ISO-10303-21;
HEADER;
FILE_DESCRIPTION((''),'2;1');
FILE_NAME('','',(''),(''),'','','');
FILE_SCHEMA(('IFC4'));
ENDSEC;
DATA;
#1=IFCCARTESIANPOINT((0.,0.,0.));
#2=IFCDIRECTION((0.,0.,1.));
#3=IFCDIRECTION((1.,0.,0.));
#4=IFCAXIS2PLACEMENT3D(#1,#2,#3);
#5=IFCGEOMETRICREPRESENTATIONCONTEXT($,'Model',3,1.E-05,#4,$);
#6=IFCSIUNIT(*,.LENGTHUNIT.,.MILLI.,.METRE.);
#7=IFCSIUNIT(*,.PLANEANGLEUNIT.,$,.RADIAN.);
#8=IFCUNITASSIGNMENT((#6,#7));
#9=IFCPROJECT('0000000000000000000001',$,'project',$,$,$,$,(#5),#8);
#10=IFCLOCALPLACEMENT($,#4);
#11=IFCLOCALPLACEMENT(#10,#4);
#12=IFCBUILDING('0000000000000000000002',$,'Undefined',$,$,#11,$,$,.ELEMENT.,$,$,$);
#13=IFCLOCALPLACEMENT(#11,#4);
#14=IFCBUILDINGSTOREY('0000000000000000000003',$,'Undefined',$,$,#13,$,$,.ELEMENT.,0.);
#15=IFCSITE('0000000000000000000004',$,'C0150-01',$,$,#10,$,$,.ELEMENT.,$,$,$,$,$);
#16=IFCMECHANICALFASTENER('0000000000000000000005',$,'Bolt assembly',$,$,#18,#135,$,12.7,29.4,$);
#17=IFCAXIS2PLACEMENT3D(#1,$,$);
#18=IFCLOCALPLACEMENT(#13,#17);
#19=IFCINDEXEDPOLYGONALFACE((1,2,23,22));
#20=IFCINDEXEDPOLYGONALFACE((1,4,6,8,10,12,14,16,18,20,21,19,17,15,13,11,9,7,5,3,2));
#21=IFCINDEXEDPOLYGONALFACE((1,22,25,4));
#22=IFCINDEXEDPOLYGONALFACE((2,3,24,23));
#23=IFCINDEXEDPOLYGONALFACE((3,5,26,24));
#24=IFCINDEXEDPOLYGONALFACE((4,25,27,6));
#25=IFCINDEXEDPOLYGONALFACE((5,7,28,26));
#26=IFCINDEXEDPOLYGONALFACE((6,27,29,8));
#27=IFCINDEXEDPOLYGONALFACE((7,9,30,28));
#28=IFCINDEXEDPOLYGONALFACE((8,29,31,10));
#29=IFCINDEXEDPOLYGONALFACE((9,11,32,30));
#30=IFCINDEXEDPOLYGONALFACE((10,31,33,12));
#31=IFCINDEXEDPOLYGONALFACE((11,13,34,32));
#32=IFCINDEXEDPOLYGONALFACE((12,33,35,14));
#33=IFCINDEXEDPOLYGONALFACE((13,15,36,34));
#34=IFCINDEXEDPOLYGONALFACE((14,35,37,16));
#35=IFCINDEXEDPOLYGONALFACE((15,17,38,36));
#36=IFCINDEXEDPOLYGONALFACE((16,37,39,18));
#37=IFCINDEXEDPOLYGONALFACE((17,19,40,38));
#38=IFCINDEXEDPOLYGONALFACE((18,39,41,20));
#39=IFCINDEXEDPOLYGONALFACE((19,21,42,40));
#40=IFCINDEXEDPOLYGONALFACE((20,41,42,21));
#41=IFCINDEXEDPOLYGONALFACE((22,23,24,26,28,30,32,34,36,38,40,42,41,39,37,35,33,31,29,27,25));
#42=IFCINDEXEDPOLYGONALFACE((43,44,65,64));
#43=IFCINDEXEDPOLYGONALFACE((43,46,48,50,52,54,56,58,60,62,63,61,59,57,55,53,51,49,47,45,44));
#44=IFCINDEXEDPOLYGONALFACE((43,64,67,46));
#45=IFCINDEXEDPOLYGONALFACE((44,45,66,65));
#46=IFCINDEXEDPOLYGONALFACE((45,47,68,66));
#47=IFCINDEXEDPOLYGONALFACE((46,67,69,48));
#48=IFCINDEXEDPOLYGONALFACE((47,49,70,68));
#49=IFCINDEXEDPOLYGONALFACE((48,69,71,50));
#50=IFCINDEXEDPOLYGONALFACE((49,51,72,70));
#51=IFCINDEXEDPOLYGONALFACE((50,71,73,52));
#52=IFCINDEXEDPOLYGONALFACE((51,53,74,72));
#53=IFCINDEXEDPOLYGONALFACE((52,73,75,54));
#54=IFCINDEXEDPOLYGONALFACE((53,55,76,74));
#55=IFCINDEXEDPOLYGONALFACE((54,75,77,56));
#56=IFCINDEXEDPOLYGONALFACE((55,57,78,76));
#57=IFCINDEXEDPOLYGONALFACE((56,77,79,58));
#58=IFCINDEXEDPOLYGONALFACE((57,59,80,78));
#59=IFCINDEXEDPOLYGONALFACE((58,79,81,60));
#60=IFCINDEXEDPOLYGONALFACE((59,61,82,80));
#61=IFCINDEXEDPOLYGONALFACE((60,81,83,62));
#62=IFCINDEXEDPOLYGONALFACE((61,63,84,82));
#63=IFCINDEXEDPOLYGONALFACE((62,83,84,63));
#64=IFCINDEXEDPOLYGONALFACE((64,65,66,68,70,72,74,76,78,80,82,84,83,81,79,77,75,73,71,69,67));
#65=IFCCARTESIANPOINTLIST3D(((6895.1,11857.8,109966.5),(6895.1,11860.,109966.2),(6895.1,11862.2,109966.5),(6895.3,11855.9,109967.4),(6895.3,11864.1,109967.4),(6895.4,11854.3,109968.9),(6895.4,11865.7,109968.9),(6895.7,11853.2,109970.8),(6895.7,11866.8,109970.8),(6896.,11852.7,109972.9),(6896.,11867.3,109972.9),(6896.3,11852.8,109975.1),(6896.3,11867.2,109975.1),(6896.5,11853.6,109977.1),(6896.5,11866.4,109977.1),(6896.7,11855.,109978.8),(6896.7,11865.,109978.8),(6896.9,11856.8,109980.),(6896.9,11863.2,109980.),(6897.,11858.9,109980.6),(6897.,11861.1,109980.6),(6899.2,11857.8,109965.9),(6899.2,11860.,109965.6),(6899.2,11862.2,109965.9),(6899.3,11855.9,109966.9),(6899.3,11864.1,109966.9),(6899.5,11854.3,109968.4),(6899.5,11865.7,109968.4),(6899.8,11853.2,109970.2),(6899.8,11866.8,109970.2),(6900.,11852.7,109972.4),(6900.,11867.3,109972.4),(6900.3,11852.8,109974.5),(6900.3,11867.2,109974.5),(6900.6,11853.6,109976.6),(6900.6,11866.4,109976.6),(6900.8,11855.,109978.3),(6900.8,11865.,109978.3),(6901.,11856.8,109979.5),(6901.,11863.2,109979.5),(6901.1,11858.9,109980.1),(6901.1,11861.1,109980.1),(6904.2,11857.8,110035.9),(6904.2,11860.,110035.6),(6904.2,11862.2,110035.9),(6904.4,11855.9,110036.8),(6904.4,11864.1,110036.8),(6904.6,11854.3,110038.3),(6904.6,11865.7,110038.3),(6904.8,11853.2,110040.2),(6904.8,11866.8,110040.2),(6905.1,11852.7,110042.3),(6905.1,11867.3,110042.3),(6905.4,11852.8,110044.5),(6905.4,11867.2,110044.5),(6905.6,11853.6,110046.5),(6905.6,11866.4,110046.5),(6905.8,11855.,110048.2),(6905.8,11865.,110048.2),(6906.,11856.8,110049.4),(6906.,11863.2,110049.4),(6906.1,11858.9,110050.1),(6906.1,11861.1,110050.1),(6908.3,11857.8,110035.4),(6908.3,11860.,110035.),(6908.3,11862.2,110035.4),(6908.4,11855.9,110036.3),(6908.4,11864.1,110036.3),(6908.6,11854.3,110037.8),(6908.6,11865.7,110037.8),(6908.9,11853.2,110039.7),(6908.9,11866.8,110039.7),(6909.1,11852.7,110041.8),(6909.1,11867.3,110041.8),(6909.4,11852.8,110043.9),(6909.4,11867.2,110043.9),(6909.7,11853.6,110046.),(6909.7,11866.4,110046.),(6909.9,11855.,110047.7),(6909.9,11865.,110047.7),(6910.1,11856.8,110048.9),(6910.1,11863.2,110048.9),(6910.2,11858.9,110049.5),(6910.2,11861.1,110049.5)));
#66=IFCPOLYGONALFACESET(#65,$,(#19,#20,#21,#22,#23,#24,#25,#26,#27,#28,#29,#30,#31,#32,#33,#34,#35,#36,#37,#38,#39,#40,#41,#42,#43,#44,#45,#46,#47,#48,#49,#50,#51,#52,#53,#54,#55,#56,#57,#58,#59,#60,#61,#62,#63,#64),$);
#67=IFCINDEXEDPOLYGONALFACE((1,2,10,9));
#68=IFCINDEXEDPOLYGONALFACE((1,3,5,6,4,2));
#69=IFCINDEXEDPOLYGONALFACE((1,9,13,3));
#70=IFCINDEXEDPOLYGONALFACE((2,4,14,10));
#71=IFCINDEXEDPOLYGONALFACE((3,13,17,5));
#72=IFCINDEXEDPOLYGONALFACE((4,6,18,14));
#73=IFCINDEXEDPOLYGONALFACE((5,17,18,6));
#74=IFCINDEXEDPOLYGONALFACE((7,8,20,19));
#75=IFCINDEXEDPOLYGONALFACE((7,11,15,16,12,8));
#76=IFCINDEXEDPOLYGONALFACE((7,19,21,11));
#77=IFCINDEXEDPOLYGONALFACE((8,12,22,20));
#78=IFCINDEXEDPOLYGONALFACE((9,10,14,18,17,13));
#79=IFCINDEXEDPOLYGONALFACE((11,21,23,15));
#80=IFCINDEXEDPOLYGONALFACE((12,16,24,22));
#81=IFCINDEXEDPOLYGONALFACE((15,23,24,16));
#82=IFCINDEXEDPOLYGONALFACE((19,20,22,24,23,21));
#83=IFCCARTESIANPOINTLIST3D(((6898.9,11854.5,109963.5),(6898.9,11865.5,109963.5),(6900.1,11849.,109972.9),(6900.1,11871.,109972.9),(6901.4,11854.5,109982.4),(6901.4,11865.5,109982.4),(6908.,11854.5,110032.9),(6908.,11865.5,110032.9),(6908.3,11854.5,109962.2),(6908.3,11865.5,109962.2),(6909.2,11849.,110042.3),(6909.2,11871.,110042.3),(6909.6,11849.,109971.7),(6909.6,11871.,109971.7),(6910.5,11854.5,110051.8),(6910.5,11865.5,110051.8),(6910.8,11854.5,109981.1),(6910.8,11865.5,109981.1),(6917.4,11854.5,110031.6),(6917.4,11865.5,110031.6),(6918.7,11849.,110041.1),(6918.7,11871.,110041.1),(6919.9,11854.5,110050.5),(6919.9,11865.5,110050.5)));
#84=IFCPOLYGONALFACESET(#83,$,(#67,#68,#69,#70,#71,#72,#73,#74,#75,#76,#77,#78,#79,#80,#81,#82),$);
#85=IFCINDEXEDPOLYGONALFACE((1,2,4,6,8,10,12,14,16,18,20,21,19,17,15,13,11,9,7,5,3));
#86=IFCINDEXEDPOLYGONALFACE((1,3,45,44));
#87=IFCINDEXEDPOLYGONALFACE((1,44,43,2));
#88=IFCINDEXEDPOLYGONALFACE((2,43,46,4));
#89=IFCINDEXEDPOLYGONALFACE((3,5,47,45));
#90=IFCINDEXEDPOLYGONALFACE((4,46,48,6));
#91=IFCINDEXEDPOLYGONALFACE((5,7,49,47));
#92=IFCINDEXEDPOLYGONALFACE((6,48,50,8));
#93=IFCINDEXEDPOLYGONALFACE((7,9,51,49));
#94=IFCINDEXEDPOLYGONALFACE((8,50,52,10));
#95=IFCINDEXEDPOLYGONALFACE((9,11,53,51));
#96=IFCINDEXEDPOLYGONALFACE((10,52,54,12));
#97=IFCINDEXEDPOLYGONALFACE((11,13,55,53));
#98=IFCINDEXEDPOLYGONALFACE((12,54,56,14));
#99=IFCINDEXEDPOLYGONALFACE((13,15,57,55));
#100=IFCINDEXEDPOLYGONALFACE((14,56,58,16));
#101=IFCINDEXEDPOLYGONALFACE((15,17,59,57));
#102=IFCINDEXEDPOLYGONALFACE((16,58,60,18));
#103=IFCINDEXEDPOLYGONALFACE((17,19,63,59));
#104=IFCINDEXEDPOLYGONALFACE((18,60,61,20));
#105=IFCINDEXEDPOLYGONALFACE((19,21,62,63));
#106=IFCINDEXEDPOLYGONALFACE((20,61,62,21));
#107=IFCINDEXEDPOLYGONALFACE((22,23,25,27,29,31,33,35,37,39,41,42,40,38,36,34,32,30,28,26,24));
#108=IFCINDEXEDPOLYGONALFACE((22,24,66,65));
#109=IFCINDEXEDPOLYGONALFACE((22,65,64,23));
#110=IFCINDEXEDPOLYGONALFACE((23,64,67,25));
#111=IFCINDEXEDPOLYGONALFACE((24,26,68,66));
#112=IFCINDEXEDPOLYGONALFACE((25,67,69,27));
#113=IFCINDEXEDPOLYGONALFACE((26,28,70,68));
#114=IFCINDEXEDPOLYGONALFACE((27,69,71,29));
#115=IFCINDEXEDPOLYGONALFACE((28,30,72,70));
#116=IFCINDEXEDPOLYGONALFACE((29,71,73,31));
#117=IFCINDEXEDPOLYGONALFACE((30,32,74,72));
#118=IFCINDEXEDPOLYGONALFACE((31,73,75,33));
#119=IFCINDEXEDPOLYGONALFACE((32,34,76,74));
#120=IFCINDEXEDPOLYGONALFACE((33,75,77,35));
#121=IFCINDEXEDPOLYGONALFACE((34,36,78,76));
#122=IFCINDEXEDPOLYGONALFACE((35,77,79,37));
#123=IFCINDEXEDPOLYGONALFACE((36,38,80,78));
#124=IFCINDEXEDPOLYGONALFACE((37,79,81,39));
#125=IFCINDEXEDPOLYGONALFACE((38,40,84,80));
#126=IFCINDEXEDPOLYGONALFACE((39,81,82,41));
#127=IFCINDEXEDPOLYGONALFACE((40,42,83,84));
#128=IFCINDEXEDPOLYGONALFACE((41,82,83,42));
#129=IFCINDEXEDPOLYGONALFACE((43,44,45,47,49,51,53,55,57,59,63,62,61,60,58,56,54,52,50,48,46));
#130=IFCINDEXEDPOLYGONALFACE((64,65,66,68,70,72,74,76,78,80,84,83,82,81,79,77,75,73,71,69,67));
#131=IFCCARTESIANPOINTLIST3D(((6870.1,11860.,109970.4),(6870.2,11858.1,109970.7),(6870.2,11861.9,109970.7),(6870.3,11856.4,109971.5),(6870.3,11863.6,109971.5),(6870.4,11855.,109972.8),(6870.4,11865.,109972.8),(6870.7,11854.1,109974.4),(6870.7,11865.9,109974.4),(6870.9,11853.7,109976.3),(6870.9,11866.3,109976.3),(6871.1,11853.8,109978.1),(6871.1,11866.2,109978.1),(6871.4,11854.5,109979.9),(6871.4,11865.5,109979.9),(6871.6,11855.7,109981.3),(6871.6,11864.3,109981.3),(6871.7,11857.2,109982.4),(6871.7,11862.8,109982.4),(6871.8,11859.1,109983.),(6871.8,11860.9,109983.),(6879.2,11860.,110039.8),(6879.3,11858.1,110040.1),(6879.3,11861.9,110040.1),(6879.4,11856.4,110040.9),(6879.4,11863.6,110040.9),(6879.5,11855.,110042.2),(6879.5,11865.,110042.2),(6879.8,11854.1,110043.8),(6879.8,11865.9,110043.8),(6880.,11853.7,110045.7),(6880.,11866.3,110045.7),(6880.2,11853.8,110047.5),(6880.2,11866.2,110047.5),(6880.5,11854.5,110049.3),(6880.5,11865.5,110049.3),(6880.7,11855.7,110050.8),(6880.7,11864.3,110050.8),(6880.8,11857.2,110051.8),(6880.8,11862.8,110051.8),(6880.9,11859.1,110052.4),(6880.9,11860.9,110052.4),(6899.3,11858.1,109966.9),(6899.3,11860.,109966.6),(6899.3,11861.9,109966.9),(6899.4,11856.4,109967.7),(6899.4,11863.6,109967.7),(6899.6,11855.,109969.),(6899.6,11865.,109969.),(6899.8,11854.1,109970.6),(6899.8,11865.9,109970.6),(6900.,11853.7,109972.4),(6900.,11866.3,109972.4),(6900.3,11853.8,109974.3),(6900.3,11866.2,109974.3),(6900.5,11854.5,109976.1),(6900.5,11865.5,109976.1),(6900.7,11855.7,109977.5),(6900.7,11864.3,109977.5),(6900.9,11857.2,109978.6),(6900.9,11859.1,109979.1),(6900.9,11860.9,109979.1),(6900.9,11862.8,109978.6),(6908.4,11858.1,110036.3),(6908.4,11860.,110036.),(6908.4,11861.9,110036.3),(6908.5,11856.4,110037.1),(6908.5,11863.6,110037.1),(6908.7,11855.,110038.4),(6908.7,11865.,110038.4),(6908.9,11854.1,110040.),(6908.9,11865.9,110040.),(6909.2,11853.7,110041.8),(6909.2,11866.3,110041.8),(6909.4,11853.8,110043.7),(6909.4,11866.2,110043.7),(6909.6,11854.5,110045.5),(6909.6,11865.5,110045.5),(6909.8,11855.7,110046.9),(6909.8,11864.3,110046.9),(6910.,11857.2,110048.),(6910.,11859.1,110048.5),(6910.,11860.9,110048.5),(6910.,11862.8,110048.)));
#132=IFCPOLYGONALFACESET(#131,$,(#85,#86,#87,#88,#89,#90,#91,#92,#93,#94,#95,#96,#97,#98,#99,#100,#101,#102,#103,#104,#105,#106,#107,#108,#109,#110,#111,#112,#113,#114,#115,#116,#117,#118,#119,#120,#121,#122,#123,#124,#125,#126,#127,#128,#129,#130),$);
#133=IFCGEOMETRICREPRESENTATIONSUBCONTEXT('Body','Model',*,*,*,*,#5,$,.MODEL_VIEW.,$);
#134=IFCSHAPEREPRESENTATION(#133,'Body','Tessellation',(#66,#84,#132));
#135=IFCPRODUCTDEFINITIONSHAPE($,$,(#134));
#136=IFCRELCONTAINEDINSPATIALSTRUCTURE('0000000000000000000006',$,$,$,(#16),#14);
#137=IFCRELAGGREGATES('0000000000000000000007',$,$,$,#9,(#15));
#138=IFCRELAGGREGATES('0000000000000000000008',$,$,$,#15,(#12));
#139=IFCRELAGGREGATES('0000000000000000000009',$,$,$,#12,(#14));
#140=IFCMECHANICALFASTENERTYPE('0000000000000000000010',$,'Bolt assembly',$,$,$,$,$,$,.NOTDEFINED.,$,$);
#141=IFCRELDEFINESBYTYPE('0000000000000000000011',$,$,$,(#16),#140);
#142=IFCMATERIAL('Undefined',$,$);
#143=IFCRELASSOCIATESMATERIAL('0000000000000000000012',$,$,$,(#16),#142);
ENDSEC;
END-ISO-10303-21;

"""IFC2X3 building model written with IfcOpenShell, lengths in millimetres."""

from ifc_helpers import new_model, si_unit, frame, origin_with_axes, origin_2d_with_axis, place, context, subcontext, project, spatial, polyline, circle, outline, extrude, source, transform, mapped, material, type_object, element, save


model = new_model("IFC2X3")

# Units and contexts
model_context = context("Model", 3, precision=1e-05, world=origin_with_axes())
body_context = subcontext(model_context, "Body", "Model", "MODEL_VIEW")
ifc_project = project(units=[si_unit("LENGTHUNIT", "METRE", prefix="MILLI"), si_unit("PLANEANGLEUNIT", "RADIAN")], contexts=[model_context])

# Site, building, storey
site_placement = place(None, origin_with_axes())
site = spatial("IfcSite", under=ifc_project, at=site_placement, Name="C0150-01", CompositionType="ELEMENT")
building_placement = place(site_placement, origin_with_axes())
building = spatial("IfcBuilding", under=site, at=building_placement, Name="Undefined", CompositionType="ELEMENT")
storey_placement = place(building_placement, origin_with_axes())
storey = spatial("IfcBuildingStorey", under=building, at=storey_placement, Name="Undefined", CompositionType="ELEMENT", Elevation=0.0)

# Mechanical fastener
ifc_material_1 = material(Name="Undefined")
mechanical_fastener_type = type_object("IfcMechanicalFastenerType", Name="Bolt assembly")
shared_shape_1 = source(origin_with_axes(), body_context, "Body", "SweptSolid", [
    extrude(circle(Radius=7.3, at=origin_2d_with_axis()), frame((0.0, 0.0, 0.0), z_axis=(0.0, 1.0, 0.0), x_axis=(1.0, 0.0, 0.0)), (0.0, 0.0, 1.0), 4.1),
    extrude(outline(polyline([(9.5, -5.5), (9.5, 5.5), (0.0, 11.0), (-9.5, 5.5), (-9.5, -5.5), (0.0, -11.0), (9.5, -5.5)])), frame((0.0, -9.5, 0.0), z_axis=(0.0, 1.0, 0.0), x_axis=(1.0, 0.0, 0.0)), (0.0, 0.0, 1.0), 9.5),
    extrude(circle(Radius=6.3, at=origin_2d_with_axis()), frame((0.0, 0.0, 0.0), z_axis=(0.0, 1.0, 0.0), x_axis=(1.0, 0.0, 0.0)), (0.0, 0.0, 1.0), 29.4),
])
for number, where, z_axis, x_axis, name in (
    (1, (6909.2, 11860.0, 110042.3), (0.0, 1.0, 0.0), (-0.130054, 0.0, -0.991507), "Bolt assembly"),
):
    element("IfcMechanicalFastener", number, at=place(storey_placement, frame(where, z_axis=z_axis, x_axis=x_axis)), inside=storey, type_object=mechanical_fastener_type, material=ifc_material_1, Name=name, NominalDiameter=12.7, NominalLength=29.4, context=body_context, shape_type="MappedRepresentation", body=[
        mapped(shared_shape_1, transform((0.0, 0.0, 0.0))),
        mapped(shared_shape_1, transform((70.0, 0.0, 0.0))),
    ])

save(model, "model.ifc")
